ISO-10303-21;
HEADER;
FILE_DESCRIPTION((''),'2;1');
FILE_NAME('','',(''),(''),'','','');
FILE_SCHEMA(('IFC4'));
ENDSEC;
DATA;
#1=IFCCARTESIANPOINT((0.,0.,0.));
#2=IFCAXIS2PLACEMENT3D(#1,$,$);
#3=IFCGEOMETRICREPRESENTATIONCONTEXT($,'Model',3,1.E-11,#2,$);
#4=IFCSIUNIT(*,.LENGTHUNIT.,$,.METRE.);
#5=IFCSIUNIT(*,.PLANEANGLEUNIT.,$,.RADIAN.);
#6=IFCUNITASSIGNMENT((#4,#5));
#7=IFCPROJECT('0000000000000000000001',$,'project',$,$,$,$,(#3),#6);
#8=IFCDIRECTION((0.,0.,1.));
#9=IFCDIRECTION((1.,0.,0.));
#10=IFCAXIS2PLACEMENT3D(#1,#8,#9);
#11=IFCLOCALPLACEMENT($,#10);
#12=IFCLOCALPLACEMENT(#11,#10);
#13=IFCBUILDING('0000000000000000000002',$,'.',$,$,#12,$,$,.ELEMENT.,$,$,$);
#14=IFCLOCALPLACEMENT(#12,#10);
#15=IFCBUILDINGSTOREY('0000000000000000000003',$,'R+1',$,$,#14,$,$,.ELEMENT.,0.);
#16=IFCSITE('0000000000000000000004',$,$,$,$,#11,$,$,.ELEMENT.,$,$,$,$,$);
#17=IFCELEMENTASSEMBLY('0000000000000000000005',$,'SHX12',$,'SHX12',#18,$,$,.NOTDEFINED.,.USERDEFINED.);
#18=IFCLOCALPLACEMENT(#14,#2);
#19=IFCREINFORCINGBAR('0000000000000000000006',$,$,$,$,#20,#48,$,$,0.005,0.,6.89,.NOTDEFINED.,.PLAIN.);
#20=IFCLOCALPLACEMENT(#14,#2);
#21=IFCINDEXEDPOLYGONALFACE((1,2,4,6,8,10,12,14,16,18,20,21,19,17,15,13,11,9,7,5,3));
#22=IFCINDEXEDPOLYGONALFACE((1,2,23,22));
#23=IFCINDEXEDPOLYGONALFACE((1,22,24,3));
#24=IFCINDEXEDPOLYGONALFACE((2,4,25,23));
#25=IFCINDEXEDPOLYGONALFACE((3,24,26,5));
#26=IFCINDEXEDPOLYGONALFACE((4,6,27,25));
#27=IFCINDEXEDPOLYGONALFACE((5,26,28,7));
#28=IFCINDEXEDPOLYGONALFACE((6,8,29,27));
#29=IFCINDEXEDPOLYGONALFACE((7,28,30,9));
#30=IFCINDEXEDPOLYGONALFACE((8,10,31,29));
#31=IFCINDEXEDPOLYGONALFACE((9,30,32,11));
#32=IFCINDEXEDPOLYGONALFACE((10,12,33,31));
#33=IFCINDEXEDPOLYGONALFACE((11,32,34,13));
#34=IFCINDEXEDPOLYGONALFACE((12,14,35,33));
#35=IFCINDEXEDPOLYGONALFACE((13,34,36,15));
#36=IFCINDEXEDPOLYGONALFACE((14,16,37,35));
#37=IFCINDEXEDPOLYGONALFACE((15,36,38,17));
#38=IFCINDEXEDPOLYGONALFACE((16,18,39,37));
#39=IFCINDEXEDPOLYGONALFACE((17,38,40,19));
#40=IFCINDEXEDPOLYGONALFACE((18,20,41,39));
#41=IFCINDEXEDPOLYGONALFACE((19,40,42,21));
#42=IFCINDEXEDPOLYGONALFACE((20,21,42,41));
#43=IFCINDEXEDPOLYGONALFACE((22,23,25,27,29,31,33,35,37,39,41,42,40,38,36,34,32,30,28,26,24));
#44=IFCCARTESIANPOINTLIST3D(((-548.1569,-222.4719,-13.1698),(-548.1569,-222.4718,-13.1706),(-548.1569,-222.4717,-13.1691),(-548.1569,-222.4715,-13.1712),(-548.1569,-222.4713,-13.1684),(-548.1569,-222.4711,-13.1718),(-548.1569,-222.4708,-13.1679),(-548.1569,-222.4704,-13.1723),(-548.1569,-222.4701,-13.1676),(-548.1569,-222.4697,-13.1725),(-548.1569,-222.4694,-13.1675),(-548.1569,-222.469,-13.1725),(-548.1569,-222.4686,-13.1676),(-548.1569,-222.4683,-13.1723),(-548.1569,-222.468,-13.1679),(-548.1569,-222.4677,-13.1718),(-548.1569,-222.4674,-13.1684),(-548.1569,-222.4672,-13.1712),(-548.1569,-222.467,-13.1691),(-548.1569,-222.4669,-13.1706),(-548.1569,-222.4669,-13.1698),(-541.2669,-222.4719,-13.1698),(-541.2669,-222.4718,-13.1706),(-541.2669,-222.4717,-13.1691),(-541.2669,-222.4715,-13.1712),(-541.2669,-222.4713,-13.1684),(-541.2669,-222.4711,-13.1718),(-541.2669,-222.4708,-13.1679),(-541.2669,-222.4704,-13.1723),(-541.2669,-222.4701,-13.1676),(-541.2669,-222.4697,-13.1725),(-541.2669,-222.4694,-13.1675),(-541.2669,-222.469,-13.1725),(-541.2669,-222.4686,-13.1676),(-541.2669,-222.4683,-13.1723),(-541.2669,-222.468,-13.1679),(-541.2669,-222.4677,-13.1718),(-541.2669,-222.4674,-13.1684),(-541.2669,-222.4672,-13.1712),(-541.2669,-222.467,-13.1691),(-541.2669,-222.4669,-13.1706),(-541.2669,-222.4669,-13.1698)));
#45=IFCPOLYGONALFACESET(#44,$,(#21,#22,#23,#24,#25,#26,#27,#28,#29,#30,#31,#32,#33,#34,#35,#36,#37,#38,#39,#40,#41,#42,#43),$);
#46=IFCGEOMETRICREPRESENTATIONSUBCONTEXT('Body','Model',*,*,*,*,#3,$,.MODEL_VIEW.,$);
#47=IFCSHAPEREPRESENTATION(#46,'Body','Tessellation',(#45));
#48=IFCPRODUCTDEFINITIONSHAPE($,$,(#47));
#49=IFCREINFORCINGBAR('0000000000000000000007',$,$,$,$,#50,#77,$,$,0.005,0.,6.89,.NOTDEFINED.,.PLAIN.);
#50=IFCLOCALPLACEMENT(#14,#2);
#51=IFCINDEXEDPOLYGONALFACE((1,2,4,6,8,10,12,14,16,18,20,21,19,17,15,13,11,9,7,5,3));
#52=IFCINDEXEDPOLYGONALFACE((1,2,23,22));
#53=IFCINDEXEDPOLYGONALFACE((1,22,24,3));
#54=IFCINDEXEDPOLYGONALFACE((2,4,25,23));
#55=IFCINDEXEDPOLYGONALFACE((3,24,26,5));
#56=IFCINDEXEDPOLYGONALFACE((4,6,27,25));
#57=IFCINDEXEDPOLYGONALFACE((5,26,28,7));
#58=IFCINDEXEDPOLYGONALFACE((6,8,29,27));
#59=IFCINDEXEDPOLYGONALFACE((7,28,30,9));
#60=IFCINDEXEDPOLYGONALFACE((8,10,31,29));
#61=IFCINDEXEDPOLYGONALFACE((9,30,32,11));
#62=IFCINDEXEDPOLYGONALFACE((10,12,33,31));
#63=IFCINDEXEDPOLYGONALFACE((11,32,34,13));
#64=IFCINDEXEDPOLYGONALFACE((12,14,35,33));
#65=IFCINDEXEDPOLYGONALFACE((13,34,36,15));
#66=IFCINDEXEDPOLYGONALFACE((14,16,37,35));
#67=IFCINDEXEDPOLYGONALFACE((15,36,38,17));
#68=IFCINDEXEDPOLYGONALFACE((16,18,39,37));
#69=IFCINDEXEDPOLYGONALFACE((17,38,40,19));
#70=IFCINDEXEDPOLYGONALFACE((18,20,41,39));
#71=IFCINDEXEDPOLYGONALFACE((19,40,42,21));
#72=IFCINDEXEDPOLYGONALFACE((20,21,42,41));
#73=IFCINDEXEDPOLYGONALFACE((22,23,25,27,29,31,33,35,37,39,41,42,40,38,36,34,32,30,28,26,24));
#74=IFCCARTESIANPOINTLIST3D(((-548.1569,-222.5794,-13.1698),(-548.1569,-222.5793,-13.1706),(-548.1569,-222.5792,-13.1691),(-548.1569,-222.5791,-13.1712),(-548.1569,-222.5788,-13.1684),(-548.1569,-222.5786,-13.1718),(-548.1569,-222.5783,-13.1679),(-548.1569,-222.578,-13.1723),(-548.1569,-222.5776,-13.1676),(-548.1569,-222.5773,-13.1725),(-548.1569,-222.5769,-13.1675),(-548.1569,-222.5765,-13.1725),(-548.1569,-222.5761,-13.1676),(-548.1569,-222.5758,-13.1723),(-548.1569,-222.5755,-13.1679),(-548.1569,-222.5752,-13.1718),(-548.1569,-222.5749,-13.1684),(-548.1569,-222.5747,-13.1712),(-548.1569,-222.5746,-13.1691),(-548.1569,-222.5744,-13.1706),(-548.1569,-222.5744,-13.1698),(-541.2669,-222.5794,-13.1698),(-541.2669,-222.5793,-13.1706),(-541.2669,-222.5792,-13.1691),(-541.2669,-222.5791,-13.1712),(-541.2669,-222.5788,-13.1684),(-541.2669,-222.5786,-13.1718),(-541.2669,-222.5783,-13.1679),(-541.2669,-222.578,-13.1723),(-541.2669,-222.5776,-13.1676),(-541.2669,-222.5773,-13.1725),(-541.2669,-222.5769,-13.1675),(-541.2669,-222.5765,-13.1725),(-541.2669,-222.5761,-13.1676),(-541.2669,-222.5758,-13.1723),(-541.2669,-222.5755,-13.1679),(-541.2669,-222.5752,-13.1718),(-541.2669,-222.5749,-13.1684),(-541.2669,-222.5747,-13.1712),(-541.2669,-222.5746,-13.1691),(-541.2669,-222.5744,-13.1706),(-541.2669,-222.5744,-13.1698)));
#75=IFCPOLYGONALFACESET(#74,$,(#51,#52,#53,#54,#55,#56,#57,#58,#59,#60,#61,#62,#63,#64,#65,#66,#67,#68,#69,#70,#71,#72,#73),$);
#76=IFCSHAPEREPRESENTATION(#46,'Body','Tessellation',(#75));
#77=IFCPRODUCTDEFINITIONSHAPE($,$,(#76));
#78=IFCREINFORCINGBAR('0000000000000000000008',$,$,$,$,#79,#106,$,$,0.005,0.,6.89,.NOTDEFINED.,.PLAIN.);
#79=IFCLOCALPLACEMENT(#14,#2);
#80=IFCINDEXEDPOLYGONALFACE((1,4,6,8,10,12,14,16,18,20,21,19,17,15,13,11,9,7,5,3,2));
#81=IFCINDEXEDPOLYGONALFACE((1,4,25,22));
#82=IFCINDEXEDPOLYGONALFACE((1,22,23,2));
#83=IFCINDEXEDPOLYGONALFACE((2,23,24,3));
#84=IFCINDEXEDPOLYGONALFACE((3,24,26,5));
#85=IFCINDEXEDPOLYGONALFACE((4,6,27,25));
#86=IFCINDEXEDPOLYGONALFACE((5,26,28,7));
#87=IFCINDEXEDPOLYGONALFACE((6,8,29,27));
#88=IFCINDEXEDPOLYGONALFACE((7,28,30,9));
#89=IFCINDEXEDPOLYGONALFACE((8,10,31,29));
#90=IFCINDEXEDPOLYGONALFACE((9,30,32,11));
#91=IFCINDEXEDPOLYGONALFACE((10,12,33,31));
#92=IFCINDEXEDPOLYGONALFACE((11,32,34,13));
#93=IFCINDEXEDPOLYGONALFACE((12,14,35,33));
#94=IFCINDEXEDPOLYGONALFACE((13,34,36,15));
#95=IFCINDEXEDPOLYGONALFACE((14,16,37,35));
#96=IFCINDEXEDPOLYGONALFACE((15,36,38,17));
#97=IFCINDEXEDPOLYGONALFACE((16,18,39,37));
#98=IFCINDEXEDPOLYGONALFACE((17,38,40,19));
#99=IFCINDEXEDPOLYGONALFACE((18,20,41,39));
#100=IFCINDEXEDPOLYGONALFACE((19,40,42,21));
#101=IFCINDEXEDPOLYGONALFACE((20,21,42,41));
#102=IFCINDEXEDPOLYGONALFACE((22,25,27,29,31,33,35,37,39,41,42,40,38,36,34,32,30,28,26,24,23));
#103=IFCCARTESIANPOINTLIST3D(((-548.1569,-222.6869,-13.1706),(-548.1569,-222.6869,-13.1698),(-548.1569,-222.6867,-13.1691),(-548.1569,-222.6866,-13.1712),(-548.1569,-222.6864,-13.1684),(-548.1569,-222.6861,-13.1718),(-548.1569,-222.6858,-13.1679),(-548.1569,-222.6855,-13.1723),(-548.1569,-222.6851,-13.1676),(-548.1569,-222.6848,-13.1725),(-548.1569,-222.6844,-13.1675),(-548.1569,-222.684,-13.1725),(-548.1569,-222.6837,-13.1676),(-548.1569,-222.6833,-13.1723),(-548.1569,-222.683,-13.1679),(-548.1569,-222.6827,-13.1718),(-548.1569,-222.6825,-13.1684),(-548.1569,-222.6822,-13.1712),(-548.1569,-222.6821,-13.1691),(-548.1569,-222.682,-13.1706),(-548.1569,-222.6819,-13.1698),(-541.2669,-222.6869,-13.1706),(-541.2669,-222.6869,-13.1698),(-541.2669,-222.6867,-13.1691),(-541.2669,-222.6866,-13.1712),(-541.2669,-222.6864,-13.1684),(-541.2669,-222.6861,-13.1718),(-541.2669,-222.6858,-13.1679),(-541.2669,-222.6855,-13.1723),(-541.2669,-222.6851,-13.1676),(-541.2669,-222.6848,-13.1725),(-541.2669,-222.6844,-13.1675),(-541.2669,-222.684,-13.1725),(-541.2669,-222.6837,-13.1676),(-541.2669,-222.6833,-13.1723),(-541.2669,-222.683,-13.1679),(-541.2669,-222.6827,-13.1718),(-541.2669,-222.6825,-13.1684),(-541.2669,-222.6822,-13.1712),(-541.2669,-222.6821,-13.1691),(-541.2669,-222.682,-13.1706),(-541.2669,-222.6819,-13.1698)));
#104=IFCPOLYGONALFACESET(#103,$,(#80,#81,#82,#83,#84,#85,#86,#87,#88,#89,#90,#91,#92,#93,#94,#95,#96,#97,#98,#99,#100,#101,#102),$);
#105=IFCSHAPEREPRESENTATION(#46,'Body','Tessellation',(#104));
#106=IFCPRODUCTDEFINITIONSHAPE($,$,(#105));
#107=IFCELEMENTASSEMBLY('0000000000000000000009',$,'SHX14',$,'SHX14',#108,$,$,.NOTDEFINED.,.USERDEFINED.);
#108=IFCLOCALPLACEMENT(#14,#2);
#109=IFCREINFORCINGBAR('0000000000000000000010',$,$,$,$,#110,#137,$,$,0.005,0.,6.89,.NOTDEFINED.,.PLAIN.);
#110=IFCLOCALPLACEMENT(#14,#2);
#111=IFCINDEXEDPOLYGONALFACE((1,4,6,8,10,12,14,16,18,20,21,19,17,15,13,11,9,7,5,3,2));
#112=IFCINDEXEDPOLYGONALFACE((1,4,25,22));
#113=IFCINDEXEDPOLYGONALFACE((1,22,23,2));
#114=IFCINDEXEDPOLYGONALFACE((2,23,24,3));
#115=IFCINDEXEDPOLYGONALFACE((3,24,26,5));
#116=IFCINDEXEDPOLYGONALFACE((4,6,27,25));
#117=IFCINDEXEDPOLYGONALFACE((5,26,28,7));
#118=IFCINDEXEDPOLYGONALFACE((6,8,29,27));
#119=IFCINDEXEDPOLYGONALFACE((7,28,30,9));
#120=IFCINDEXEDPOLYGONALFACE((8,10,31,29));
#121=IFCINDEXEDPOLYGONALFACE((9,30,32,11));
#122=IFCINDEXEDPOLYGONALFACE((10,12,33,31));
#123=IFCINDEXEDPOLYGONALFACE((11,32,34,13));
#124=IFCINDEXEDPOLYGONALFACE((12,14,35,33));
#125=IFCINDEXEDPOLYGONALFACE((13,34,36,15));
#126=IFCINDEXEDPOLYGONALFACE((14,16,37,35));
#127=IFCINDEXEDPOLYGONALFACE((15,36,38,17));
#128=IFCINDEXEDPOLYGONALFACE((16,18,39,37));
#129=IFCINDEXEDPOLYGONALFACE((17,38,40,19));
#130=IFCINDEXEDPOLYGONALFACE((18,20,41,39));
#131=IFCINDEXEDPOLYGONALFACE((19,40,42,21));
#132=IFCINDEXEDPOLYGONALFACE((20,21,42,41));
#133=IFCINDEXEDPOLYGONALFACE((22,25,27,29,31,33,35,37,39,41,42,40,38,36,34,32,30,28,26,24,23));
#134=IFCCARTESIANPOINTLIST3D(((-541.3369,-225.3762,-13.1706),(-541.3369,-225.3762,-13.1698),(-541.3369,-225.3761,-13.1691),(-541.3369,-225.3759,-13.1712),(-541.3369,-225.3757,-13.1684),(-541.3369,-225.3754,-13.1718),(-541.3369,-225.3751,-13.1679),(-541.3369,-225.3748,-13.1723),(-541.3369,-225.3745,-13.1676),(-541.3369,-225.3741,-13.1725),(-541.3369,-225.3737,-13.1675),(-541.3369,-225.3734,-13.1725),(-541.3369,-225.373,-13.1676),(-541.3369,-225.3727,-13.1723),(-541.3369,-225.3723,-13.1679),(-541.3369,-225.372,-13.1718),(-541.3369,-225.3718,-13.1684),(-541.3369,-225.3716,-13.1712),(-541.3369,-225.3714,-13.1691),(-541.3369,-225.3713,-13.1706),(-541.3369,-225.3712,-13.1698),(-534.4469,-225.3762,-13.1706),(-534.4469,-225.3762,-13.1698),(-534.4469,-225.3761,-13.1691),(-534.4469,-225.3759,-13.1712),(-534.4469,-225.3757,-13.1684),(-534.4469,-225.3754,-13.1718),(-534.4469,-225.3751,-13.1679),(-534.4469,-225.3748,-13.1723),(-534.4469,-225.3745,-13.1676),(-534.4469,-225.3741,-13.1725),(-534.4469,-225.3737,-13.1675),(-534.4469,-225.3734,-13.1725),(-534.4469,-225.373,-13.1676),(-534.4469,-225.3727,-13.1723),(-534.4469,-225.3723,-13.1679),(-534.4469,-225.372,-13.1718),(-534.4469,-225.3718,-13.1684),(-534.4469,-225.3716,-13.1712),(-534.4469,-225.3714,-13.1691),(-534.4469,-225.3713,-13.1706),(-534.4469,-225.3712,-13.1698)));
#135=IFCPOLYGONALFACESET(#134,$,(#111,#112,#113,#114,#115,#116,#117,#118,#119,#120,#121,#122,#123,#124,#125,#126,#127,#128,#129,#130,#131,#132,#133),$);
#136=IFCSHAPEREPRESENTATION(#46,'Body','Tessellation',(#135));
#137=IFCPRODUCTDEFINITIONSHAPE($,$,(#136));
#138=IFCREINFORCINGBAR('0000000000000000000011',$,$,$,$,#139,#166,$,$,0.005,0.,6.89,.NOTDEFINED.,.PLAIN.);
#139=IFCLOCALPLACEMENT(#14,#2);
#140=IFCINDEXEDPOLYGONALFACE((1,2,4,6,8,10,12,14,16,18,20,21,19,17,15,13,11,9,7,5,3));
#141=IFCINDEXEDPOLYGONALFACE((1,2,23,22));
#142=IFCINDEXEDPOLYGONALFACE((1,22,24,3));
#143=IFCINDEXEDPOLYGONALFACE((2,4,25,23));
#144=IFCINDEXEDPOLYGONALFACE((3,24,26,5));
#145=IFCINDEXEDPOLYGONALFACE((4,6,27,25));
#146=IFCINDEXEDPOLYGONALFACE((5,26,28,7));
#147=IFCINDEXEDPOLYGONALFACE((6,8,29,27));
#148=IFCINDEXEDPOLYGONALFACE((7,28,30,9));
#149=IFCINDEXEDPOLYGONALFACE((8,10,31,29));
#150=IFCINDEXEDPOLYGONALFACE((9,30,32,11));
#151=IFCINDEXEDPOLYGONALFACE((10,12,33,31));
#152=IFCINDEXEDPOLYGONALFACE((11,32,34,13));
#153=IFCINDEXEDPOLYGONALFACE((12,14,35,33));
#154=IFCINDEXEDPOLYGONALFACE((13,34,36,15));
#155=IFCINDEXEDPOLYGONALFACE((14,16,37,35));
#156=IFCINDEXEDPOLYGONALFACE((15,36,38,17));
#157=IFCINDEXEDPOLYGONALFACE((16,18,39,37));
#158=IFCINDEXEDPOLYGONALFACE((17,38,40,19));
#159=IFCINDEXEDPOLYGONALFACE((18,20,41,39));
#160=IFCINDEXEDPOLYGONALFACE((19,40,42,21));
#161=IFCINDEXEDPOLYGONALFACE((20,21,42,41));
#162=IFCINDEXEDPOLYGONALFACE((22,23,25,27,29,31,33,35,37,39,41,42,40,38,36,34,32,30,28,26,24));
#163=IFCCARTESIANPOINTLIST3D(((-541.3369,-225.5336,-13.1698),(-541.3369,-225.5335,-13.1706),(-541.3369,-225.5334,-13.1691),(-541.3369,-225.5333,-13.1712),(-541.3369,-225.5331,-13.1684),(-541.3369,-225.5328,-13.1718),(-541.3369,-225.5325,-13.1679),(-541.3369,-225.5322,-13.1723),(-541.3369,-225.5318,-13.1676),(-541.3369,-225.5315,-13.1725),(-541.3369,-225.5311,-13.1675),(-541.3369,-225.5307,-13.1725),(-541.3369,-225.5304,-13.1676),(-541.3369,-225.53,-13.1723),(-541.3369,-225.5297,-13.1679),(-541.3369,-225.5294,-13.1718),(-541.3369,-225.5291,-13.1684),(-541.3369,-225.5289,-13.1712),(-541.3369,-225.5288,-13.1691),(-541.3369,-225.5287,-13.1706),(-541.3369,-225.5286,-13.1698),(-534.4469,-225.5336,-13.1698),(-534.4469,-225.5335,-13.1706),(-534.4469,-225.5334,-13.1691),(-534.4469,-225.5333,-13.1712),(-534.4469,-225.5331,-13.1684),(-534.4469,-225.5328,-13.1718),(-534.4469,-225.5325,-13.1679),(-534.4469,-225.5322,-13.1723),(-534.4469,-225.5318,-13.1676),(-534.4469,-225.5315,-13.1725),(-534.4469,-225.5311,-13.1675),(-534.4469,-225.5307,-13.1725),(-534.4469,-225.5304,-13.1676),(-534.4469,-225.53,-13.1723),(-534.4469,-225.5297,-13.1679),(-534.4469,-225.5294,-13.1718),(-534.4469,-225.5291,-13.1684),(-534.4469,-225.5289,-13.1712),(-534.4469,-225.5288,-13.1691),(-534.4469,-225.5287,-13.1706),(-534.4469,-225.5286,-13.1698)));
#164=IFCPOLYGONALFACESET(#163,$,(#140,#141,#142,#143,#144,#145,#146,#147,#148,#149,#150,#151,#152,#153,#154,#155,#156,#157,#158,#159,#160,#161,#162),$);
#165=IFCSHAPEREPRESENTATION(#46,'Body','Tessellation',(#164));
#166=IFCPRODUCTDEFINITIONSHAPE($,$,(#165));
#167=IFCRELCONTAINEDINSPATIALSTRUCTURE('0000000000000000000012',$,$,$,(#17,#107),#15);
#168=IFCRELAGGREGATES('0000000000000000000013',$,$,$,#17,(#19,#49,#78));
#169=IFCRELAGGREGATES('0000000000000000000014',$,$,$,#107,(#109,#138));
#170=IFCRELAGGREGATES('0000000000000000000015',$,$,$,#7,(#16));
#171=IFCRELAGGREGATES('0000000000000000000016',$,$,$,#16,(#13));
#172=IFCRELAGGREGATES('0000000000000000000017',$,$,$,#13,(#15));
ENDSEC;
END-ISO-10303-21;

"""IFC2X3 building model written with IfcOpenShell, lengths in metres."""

from ifc_helpers import new_model, entity, si_unit, origin, origin_with_axes, place, context, subcontext, project, spatial, shape, element, aggregate, save


model = new_model("IFC2X3")

# Units and contexts
model_context = context("Model", 3, precision=1e-11, world=origin())
body_context = subcontext(model_context, "Body", "Model", "MODEL_VIEW")
ifc_project = project(units=[si_unit("LENGTHUNIT", "METRE"), si_unit("PLANEANGLEUNIT", "RADIAN")], contexts=[model_context])

# Site, building, storey
site_placement = place(None, origin_with_axes())
site = spatial("IfcSite", under=ifc_project, at=site_placement, CompositionType="ELEMENT")
building_placement = place(site_placement, origin_with_axes())
building = spatial("IfcBuilding", under=site, at=building_placement, Name=".", CompositionType="ELEMENT")
storey_placement = place(building_placement, origin_with_axes())
storey = spatial("IfcBuildingStorey", under=building, at=storey_placement, Name="R+1", CompositionType="ELEMENT", Elevation=0.0)

# Element assemblies, reinforcing bars
assembly_1_placement = place(storey_placement, origin_with_axes())
assembly_1 = element("IfcElementAssembly", 1, at=assembly_1_placement, inside=storey, Name="SHX12", ObjectType="SHX12", AssemblyPlace="NOTDEFINED", PredefinedType="USERDEFINED")
reinforcing_bar_1_placement = place(assembly_1_placement, origin_with_axes())
reinforcing_bar_1 = element("IfcReinforcingBar", 2, at=reinforcing_bar_1_placement, BarLength=6.89, BarRole="NOTDEFINED", BarSurface="PLAIN", CrossSectionArea=0.0, NominalDiameter=0.005, shapes=[
    shape(body_context, "Body", "AdvancedSweptSolid", [entity("IfcSweptDiskSolid", entity("IfcPolyline", [entity("IfcCartesianPoint", [541.2669, 222.4694, 13.17]), entity("IfcCartesianPoint", [548.1569, 222.4694, 13.17])]), 0.0025, None, 0.0, 6.89)]),
    shape(body_context, "Body", "AdvancedSweptSolid", [entity("IfcSweptDiskSolid", entity("IfcPolyline", [entity("IfcCartesianPoint", [541.2669, 222.4694, 13.17]), entity("IfcCartesianPoint", [548.1569, 222.4694, 13.17])]), 0.0025, None, 0.0, 6.89)]),
])
reinforcing_bar_2_placement = place(assembly_1_placement, origin_with_axes())
reinforcing_bar_2 = element("IfcReinforcingBar", 3, at=reinforcing_bar_2_placement, BarLength=6.89, BarRole="NOTDEFINED", BarSurface="PLAIN", CrossSectionArea=0.0, NominalDiameter=0.005, shapes=[
    shape(body_context, "Body", "AdvancedSweptSolid", [entity("IfcSweptDiskSolid", entity("IfcPolyline", [entity("IfcCartesianPoint", [541.2669, 222.5769, 13.17]), entity("IfcCartesianPoint", [548.1569, 222.5769, 13.17])]), 0.0025, None, 0.0, 6.89)]),
    shape(body_context, "Body", "AdvancedSweptSolid", [entity("IfcSweptDiskSolid", entity("IfcPolyline", [entity("IfcCartesianPoint", [541.2669, 222.5769, 13.17]), entity("IfcCartesianPoint", [548.1569, 222.5769, 13.17])]), 0.0025, None, 0.0, 6.89)]),
])
reinforcing_bar_3_placement = place(assembly_1_placement, origin_with_axes())
reinforcing_bar_3 = element("IfcReinforcingBar", 4, at=reinforcing_bar_3_placement, BarLength=6.89, BarRole="NOTDEFINED", BarSurface="PLAIN", CrossSectionArea=0.0, NominalDiameter=0.005, shapes=[
    shape(body_context, "Body", "AdvancedSweptSolid", [entity("IfcSweptDiskSolid", entity("IfcPolyline", [entity("IfcCartesianPoint", [541.2669, 222.6844, 13.17]), entity("IfcCartesianPoint", [548.1569, 222.6844, 13.17])]), 0.0025, None, 0.0, 6.89)]),
    shape(body_context, "Body", "AdvancedSweptSolid", [entity("IfcSweptDiskSolid", entity("IfcPolyline", [entity("IfcCartesianPoint", [541.2669, 222.6844, 13.17]), entity("IfcCartesianPoint", [548.1569, 222.6844, 13.17])]), 0.0025, None, 0.0, 6.89)]),
])
aggregate(assembly_1, [reinforcing_bar_1, reinforcing_bar_2, reinforcing_bar_3])
assembly_2_placement = place(storey_placement, origin_with_axes())
assembly_2 = element("IfcElementAssembly", 5, at=assembly_2_placement, inside=storey, Name="SHX14", ObjectType="SHX14", AssemblyPlace="NOTDEFINED", PredefinedType="USERDEFINED")
reinforcing_bar_4_placement = place(assembly_2_placement, origin_with_axes())
reinforcing_bar_4 = element("IfcReinforcingBar", 6, at=reinforcing_bar_4_placement, BarLength=6.89, BarRole="NOTDEFINED", BarSurface="PLAIN", CrossSectionArea=0.0, NominalDiameter=0.005, shapes=[
    shape(body_context, "Body", "AdvancedSweptSolid", [entity("IfcSweptDiskSolid", entity("IfcPolyline", [entity("IfcCartesianPoint", [534.4469, 225.3737, 13.17]), entity("IfcCartesianPoint", [541.3369, 225.3737, 13.17])]), 0.0025, None, 0.0, 6.89)]),
    shape(body_context, "Body", "AdvancedSweptSolid", [entity("IfcSweptDiskSolid", entity("IfcPolyline", [entity("IfcCartesianPoint", [534.4469, 225.3737, 13.17]), entity("IfcCartesianPoint", [541.3369, 225.3737, 13.17])]), 0.0025, None, 0.0, 6.89)]),
])
reinforcing_bar_5_placement = place(assembly_2_placement, origin_with_axes())
reinforcing_bar_5 = element("IfcReinforcingBar", 7, at=reinforcing_bar_5_placement, BarLength=6.89, BarRole="NOTDEFINED", BarSurface="PLAIN", CrossSectionArea=0.0, NominalDiameter=0.005, shapes=[
    shape(body_context, "Body", "AdvancedSweptSolid", [entity("IfcSweptDiskSolid", entity("IfcPolyline", [entity("IfcCartesianPoint", [534.4469, 225.5311, 13.17]), entity("IfcCartesianPoint", [541.3369, 225.5311, 13.17])]), 0.0025, None, 0.0, 6.89)]),
    shape(body_context, "Body", "AdvancedSweptSolid", [entity("IfcSweptDiskSolid", entity("IfcPolyline", [entity("IfcCartesianPoint", [534.4469, 225.5311, 13.17]), entity("IfcCartesianPoint", [541.3369, 225.5311, 13.17])]), 0.0025, None, 0.0, 6.89)]),
])
aggregate(assembly_2, [reinforcing_bar_4, reinforcing_bar_5])

save(model, "model.ifc")
